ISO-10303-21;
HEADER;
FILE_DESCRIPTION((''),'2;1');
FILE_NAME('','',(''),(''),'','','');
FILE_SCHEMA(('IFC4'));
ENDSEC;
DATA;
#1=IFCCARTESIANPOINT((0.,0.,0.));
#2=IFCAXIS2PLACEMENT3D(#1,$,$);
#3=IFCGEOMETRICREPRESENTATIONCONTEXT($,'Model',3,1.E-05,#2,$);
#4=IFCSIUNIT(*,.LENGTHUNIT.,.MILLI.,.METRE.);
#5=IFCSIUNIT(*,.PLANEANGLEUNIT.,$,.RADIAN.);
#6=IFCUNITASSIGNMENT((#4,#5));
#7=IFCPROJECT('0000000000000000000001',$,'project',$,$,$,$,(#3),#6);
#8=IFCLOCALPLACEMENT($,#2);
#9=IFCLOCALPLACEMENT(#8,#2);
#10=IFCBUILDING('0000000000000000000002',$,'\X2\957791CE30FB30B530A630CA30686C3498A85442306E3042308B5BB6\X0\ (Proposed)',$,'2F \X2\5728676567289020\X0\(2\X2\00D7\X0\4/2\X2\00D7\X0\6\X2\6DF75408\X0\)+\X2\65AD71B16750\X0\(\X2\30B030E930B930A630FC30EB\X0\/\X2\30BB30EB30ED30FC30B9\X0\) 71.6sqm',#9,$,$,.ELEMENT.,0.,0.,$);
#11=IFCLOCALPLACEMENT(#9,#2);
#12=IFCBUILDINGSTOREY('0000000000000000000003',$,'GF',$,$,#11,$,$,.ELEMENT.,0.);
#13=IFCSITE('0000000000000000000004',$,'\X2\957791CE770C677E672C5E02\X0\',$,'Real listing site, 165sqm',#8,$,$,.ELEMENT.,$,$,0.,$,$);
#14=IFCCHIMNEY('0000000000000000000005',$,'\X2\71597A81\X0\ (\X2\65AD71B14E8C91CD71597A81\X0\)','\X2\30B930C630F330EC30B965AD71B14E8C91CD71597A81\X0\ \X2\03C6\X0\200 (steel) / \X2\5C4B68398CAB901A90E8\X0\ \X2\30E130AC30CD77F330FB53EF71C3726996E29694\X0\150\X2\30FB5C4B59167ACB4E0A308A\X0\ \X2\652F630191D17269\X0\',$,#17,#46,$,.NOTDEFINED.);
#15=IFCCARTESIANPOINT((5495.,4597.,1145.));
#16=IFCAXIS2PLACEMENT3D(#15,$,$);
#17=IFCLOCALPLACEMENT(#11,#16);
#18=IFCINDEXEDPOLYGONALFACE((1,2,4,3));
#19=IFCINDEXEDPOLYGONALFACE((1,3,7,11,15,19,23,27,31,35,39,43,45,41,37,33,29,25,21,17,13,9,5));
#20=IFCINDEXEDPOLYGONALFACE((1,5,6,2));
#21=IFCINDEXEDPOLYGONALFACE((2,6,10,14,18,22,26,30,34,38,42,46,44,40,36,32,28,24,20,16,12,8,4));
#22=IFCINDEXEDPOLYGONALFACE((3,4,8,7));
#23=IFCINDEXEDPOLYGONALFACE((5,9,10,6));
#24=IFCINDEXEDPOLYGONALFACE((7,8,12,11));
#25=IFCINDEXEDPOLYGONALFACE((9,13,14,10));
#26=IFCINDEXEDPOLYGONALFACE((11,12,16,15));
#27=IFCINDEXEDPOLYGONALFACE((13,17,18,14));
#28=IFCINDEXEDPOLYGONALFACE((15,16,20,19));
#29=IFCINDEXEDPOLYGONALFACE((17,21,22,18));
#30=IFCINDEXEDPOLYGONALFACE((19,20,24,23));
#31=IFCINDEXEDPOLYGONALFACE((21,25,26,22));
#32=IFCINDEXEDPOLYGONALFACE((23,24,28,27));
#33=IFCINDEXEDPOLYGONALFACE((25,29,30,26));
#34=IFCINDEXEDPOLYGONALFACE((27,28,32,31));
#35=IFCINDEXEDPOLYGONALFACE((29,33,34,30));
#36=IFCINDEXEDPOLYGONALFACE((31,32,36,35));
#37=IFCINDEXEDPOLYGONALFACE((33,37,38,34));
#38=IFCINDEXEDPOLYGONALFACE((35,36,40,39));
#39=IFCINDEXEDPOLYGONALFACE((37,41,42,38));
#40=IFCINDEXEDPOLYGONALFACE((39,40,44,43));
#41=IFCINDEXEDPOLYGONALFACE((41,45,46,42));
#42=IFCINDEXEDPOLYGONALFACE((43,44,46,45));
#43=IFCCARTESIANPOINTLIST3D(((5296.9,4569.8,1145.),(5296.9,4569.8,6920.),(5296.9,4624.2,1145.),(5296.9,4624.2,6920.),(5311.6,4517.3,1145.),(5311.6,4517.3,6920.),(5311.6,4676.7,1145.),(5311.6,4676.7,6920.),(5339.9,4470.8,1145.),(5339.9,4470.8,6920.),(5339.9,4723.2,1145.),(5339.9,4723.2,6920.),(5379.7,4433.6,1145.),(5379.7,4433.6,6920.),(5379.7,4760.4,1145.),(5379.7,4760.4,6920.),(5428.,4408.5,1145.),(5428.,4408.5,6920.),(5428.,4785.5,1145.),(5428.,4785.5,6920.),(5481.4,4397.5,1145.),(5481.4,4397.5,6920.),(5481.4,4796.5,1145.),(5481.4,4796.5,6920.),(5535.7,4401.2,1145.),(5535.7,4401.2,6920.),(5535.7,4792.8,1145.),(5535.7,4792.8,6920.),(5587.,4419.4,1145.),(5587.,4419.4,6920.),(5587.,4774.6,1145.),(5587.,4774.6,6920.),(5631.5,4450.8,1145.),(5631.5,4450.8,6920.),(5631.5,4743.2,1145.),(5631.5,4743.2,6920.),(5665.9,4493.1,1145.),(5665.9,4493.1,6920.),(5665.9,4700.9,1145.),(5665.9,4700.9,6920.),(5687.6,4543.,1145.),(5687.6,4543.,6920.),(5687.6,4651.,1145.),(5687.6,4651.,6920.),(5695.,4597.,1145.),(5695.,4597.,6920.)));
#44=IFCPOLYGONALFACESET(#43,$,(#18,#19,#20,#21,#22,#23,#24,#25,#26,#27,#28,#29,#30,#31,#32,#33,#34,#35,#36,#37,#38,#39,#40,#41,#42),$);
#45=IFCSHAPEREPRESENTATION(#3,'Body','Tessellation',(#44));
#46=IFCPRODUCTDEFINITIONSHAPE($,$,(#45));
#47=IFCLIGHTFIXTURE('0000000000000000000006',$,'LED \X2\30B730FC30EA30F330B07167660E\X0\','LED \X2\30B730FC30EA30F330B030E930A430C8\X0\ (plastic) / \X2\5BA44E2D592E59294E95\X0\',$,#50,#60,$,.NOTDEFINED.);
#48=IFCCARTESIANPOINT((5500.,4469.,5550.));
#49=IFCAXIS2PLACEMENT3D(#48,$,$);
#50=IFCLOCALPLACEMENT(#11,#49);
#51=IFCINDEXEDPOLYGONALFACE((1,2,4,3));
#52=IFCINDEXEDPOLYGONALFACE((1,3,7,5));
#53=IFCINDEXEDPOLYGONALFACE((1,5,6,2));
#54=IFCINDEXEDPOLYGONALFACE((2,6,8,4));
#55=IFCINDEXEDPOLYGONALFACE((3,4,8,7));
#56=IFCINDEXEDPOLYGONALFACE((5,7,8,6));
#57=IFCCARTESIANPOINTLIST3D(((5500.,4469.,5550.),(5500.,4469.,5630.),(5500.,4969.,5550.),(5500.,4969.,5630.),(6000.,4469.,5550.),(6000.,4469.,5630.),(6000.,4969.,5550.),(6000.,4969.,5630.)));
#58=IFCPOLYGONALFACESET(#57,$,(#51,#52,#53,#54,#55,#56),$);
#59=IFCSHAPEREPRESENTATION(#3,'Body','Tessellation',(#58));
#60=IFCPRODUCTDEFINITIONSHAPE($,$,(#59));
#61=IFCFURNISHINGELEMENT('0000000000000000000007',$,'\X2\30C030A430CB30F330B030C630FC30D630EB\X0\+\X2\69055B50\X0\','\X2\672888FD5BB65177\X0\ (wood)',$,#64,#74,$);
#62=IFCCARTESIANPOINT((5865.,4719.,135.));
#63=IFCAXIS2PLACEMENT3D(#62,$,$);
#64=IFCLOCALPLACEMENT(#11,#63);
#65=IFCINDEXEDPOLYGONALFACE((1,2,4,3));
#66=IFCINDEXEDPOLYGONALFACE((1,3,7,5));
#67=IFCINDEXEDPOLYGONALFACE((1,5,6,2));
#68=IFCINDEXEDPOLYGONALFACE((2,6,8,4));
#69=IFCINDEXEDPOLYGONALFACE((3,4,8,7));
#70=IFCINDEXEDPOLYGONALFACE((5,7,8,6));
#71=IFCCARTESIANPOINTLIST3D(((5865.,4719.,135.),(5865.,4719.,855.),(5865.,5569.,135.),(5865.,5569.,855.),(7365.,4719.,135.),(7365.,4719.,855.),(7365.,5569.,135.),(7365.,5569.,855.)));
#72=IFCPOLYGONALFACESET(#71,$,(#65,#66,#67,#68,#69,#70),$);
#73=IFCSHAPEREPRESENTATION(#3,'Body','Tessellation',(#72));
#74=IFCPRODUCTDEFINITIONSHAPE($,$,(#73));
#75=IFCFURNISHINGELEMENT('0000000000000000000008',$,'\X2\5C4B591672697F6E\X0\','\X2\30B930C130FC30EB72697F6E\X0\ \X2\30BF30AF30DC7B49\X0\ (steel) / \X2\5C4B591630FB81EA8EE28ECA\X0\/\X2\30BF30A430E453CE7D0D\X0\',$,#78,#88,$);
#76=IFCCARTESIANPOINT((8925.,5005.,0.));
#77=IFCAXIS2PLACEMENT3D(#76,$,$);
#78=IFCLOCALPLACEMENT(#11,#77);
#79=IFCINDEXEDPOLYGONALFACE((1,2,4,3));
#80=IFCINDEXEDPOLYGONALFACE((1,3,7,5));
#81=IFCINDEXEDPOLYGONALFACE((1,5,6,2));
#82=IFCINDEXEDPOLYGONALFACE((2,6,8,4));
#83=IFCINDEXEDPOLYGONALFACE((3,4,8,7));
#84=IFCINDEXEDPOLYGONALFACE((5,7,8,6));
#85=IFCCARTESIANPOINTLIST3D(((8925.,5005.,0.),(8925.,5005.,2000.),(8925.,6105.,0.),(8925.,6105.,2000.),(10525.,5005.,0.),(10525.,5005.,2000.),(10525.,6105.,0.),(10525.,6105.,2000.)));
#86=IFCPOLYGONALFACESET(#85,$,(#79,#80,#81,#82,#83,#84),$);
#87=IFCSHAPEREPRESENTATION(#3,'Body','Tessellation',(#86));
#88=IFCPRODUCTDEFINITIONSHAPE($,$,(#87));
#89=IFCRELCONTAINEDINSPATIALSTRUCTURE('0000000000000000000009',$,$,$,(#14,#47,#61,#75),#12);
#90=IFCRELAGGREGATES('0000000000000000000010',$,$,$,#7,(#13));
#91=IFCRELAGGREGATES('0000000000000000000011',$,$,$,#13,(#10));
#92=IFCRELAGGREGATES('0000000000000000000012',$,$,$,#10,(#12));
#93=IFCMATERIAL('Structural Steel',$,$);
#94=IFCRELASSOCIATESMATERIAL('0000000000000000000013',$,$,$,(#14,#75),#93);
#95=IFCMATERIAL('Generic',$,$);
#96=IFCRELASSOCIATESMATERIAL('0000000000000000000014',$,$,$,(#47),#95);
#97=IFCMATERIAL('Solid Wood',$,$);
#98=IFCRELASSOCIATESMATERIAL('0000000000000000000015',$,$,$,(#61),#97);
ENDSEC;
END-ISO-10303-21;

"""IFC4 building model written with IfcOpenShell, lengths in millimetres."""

from ifc_helpers import new_model, si_unit, frame, frame_2d, origin, origin_2d, place, context, project, spatial, rectangle, circle, extrude, material, element, save


model = new_model("IFC4")

# Units and contexts
model_context = context("Model", 3, precision=1e-05, world=origin())
ifc_project = project(units=[si_unit("LENGTHUNIT", "METRE", prefix="MILLI"), si_unit("PLANEANGLEUNIT", "RADIAN")], contexts=[model_context])

# Site, building, storey
site_placement = place(None, origin())
site = spatial("IfcSite", under=ifc_project, at=site_placement, Name="長野県松本市", ObjectType="Real listing site, 165sqm", CompositionType="ELEMENT", RefElevation=0.0)
building_placement = place(site_placement, origin())
building = spatial("IfcBuilding", under=site, at=building_placement, Name="長野・サウナと水風呂のある家 (Proposed)", ObjectType="2F 在来木造(2×4/2×6混合)+断熱材(グラスウール/セルロース) 71.6sqm", CompositionType="ELEMENT", ElevationOfRefHeight=0.0, ElevationOfTerrain=0.0)
storey_placement = place(building_placement, origin())
storey = spatial("IfcBuildingStorey", under=building, at=storey_placement, Name="GF", CompositionType="ELEMENT", Elevation=0.0)

# Shared definitions
ifc_material_1 = material(Name="Solid Wood")

# Shared definitions
ifc_material_2 = material(Name="Structural Steel")

# Chimney
chimney_placement = place(storey_placement, frame((5495.0, 4597.0, 1145.0)))
element("IfcChimney", 1, at=chimney_placement, inside=storey, material=ifc_material_2, Name="煙突 (断熱二重煙突)", Description="ステンレス断熱二重煙突 φ200 (steel) / 屋根貫通部 メガネ石・可燃物離隔150・屋外立上り 支持金物", PredefinedType="NOTDEFINED", context=model_context, shape_type="SweptSolid", body=[
    extrude(circle(Radius=200.0, at=origin_2d()), frame((5495.0, 4597.0, 1145.0)), (0.0, 0.0, 1.0), 5775.0),
])

# Light fixture
ifc_material_3 = material(Name="Generic")
light_fixture_placement = place(storey_placement, frame((5500.0, 4469.0, 5550.0)))
element("IfcLightFixture", 2, at=light_fixture_placement, inside=storey, material=ifc_material_3, Name="LED シーリング照明", Description="LED シーリングライト (plastic) / 室中央天井", PredefinedType="NOTDEFINED", context=model_context, shape_type="SweptSolid", body=[
    extrude(rectangle(XDim=500.0, YDim=500.0, at=frame_2d((250.0, 250.0))), frame((5500.0, 4469.0, 5550.0)), (0.0, 0.0, 1.0), 80.0),
])

# Furnishing elements
furnishing_1_placement = place(storey_placement, frame((5865.0, 4719.0, 135.0)))
element("IfcFurnishingElement", 3, at=furnishing_1_placement, inside=storey, material=ifc_material_1, Name="ダイニングテーブル+椅子", Description="木製家具 (wood)", context=model_context, shape_type="SweptSolid", body=[
    extrude(rectangle(XDim=1500.0, YDim=850.0, at=frame_2d((750.0, 425.0))), frame((5865.0, 4719.0, 135.0)), (0.0, 0.0, 1.0), 720.0),
])
furnishing_2_placement = place(storey_placement, frame((8925.0, 5005.0, 0.0)))
element("IfcFurnishingElement", 4, at=furnishing_2_placement, inside=storey, material=ifc_material_2, Name="屋外物置", Description="スチール物置 タクボ等 (steel) / 屋外・自転車/タイヤ収納", context=model_context, shape_type="SweptSolid", body=[
    extrude(rectangle(XDim=1600.0, YDim=1100.0, at=frame_2d((800.0, 550.0))), frame((8925.0, 5005.0, 0.0)), (0.0, 0.0, 1.0), 2000.0),
])

save(model, "model.ifc")
